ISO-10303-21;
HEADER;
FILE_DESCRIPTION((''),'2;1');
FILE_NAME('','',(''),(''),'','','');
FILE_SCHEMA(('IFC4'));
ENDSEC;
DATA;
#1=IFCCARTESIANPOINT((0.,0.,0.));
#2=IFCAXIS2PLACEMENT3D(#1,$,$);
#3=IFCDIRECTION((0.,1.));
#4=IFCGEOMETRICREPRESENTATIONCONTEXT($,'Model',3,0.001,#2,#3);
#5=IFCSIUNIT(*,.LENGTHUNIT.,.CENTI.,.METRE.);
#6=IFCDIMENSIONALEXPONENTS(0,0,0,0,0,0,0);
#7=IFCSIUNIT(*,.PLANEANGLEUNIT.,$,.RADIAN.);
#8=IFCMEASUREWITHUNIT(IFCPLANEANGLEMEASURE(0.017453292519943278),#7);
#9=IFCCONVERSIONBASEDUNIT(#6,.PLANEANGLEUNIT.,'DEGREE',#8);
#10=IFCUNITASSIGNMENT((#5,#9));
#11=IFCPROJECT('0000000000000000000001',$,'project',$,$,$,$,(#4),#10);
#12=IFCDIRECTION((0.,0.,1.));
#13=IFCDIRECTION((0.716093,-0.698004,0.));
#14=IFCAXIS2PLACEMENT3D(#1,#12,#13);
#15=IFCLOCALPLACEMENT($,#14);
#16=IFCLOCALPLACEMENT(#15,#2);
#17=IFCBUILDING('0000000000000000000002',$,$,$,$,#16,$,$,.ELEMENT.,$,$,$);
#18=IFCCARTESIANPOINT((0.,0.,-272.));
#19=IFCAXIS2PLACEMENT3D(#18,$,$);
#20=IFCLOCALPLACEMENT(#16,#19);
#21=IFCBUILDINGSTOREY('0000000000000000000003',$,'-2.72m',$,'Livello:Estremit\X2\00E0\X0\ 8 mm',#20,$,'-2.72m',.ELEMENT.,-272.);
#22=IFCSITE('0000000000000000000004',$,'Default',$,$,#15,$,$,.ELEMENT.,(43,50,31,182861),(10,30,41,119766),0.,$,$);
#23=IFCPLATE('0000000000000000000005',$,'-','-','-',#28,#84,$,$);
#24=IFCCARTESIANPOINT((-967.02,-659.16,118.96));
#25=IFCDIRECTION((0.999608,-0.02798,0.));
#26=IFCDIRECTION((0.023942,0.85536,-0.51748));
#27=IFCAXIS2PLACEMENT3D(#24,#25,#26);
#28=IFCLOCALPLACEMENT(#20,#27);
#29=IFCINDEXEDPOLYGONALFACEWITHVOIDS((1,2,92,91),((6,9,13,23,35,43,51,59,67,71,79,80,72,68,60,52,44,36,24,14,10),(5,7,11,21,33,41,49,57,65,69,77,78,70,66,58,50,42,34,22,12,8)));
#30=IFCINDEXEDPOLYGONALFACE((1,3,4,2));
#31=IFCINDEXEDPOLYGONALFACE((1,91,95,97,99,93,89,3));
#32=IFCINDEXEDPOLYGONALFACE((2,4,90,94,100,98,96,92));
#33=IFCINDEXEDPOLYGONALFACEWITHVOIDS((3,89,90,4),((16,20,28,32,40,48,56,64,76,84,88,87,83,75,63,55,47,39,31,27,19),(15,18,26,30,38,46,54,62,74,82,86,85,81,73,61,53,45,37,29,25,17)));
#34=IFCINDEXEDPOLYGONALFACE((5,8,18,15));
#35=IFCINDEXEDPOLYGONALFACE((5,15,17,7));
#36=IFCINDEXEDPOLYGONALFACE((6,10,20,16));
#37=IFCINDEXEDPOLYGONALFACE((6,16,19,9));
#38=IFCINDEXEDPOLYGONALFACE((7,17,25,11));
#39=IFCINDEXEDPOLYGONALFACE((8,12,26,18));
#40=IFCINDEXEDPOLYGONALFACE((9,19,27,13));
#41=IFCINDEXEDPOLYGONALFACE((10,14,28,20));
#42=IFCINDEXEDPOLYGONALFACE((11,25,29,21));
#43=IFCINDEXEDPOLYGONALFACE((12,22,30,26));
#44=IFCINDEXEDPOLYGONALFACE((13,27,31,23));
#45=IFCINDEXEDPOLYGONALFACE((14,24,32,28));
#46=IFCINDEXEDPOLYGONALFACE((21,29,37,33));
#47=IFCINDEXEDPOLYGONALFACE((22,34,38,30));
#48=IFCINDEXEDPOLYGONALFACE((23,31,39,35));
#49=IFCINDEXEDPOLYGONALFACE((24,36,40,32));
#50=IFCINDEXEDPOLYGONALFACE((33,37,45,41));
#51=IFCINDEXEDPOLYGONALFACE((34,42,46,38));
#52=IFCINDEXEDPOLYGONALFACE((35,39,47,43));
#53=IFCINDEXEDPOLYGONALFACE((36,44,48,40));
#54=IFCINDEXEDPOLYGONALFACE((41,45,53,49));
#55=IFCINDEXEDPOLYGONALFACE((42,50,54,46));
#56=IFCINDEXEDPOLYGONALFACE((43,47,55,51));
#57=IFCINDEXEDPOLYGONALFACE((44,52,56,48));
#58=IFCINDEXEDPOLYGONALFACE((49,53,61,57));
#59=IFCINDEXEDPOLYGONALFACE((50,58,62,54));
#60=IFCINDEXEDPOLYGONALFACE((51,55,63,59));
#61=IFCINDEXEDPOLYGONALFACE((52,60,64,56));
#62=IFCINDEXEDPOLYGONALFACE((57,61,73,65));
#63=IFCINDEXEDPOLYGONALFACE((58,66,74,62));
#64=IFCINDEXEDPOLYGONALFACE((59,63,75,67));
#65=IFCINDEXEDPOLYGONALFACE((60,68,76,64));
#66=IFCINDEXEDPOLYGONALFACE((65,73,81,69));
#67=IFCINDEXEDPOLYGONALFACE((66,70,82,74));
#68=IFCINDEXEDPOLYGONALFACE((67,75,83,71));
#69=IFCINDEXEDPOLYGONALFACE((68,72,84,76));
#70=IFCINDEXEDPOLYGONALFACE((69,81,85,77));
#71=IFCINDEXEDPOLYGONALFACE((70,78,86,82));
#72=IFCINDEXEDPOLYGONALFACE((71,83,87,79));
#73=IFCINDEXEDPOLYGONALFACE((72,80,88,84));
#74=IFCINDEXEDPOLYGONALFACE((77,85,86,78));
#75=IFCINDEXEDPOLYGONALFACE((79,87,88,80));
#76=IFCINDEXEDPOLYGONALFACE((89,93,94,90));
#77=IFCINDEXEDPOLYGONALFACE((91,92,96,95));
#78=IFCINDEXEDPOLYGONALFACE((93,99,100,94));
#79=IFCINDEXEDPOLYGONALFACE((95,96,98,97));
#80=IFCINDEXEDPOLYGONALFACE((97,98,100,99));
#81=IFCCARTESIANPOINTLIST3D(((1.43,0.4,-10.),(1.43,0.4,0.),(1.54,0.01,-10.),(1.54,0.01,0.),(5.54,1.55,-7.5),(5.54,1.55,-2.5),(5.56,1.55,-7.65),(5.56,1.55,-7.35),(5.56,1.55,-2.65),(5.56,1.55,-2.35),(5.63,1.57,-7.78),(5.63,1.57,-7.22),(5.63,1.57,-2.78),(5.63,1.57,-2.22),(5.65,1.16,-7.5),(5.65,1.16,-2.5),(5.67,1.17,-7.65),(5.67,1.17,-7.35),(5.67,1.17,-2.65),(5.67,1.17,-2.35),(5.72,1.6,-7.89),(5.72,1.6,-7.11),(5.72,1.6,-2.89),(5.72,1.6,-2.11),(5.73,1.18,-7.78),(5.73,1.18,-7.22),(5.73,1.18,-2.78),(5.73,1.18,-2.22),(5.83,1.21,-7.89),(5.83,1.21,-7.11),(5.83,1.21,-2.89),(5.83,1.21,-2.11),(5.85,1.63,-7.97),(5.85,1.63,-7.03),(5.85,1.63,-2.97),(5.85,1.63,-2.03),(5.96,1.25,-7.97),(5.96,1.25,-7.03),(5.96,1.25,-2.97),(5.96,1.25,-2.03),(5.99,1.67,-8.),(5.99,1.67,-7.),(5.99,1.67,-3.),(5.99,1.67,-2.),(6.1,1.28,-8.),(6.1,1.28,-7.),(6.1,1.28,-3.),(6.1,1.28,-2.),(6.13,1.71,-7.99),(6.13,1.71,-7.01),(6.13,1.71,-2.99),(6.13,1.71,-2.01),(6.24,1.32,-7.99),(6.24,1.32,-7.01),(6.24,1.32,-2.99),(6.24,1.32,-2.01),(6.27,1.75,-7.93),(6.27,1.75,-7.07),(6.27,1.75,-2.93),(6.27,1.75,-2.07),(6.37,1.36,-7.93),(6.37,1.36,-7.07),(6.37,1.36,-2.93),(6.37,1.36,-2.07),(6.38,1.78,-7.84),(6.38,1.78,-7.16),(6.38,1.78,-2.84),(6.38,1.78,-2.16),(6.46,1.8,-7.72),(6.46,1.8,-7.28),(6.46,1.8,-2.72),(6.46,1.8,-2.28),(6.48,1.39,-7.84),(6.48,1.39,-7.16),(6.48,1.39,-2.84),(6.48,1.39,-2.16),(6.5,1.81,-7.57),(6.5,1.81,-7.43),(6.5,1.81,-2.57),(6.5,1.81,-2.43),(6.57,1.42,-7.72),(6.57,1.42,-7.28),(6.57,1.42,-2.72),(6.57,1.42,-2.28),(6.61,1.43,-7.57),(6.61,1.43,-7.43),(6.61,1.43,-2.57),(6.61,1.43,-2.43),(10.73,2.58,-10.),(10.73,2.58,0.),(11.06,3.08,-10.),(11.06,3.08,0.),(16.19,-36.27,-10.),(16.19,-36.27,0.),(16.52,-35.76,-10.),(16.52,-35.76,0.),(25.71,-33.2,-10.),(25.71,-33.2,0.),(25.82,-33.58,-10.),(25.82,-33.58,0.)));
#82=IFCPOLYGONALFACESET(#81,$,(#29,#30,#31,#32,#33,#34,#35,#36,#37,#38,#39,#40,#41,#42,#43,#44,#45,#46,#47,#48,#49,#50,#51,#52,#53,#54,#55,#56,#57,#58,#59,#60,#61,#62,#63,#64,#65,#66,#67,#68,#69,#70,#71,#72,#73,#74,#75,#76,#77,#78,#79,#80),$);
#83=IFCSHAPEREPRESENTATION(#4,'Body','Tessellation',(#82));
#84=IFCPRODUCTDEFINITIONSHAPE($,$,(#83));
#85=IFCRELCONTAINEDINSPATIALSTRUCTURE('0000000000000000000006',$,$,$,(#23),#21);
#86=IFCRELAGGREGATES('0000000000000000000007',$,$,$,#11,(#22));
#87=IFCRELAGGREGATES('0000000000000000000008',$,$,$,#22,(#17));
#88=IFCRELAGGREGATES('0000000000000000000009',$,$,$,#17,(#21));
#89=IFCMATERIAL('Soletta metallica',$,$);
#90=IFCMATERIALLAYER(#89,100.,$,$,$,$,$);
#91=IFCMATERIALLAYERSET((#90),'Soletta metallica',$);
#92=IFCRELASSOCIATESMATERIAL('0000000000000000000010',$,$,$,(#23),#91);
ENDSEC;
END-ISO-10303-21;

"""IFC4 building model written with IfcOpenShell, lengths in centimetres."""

from ifc_helpers import new_model, entity, si_unit, converted_unit, direction, frame, frame_2d, origin, origin_with_axes, place, context, project, spatial, polyline, circle, outline, extrude, material, layer, layer_set, element, save


model = new_model("IFC4")

# Units and contexts
model_context = context("Model", 3, precision=0.001, world=origin(), true_north=direction((0.0, 1.0)))
ifc_project = project(units=[si_unit("LENGTHUNIT", "METRE", prefix="CENTI"), converted_unit("PLANEANGLEUNIT", "DEGREE", entity("IfcPlaneAngleMeasure", 0.017453292519943278), si_unit("PLANEANGLEUNIT", "RADIAN"), dimensions=[0, 0, 0, 0, 0, 0, 0])], contexts=[model_context])

# Site, building, storey
site_placement = place(None, frame((0.0, 0.0, 0.0), z_axis=(0.0, 0.0, 1.0), x_axis=(0.716093, -0.698004, 0.0)))
site = spatial("IfcSite", under=ifc_project, at=site_placement, Name="Default", CompositionType="ELEMENT", RefLatitude=(43, 50, 31, 182861), RefLongitude=(10, 30, 41, 119766), RefElevation=0.0)
building_placement = place(site_placement, origin())
building = spatial("IfcBuilding", under=site, at=building_placement, CompositionType="ELEMENT")
storey_placement = place(building_placement, frame((0.0, 0.0, -272.0)))
storey = spatial("IfcBuildingStorey", under=building, at=storey_placement, Name="-2.72m", ObjectType="Livello:Estremità 8 mm", LongName="-2.72m", CompositionType="ELEMENT", Elevation=-272.0)

# Plate, openings
ifc_material = material(Name="Soletta metallica")
ifc_layer = layer(ifc_material, 100.0)
ifc_layer_set = layer_set([ifc_layer], Name="Soletta metallica")
plate_placement = place(storey_placement, frame((-967.02, -659.16, 118.96), z_axis=(0.999608, -0.02798, 0.0), x_axis=(0.023942, 0.85536, -0.51748)))
plate = element("IfcPlate", 1, at=plate_placement, inside=storey, material=ifc_layer_set, Name="-", Description="-", ObjectType="-", context=model_context, shape_type="SweptSolid", body=[
    extrude(outline(polyline([(1.54, 0.01), (10.73, 2.58), (16.19, -36.27), (25.82, -33.58), (25.71, -33.2), (16.52, -35.76), (11.06, 3.08), (1.43, 0.4), (1.54, 0.01)])), origin_with_axes(), (0.0, 0.0, -1.0), 10.0),
])
opening_1_placement = place(plate_placement, frame((5.78, 2.55, -3.0), z_axis=(-0.268612, 0.963248, 0.0), x_axis=(-0.963248, -0.268612, 0.0)))
element("IfcOpeningElement", 2, at=opening_1_placement, cuts=plate, ObjectType="Opening", context=model_context, shape_type="SweptSolid", body=[
    extrude(circle(Radius=0.5, at=frame_2d((0.0, 0.5), x_axis=(1.0, 0.0))), origin(), (0.0, 0.0, -1.0), 1.35),
])
opening_2_placement = place(plate_placement, frame((5.78, 2.55, -8.0), z_axis=(-0.268612, 0.963248, 0.0), x_axis=(-0.963248, -0.268612, 0.0)))
element("IfcOpeningElement", 3, at=opening_2_placement, cuts=plate, ObjectType="Opening", context=model_context, shape_type="SweptSolid", body=[
    extrude(circle(Radius=0.5, at=frame_2d((0.0, 0.5), x_axis=(1.0, 0.0))), origin(), (0.0, 0.0, -1.0), 1.35),
])

save(model, "model.ifc")
